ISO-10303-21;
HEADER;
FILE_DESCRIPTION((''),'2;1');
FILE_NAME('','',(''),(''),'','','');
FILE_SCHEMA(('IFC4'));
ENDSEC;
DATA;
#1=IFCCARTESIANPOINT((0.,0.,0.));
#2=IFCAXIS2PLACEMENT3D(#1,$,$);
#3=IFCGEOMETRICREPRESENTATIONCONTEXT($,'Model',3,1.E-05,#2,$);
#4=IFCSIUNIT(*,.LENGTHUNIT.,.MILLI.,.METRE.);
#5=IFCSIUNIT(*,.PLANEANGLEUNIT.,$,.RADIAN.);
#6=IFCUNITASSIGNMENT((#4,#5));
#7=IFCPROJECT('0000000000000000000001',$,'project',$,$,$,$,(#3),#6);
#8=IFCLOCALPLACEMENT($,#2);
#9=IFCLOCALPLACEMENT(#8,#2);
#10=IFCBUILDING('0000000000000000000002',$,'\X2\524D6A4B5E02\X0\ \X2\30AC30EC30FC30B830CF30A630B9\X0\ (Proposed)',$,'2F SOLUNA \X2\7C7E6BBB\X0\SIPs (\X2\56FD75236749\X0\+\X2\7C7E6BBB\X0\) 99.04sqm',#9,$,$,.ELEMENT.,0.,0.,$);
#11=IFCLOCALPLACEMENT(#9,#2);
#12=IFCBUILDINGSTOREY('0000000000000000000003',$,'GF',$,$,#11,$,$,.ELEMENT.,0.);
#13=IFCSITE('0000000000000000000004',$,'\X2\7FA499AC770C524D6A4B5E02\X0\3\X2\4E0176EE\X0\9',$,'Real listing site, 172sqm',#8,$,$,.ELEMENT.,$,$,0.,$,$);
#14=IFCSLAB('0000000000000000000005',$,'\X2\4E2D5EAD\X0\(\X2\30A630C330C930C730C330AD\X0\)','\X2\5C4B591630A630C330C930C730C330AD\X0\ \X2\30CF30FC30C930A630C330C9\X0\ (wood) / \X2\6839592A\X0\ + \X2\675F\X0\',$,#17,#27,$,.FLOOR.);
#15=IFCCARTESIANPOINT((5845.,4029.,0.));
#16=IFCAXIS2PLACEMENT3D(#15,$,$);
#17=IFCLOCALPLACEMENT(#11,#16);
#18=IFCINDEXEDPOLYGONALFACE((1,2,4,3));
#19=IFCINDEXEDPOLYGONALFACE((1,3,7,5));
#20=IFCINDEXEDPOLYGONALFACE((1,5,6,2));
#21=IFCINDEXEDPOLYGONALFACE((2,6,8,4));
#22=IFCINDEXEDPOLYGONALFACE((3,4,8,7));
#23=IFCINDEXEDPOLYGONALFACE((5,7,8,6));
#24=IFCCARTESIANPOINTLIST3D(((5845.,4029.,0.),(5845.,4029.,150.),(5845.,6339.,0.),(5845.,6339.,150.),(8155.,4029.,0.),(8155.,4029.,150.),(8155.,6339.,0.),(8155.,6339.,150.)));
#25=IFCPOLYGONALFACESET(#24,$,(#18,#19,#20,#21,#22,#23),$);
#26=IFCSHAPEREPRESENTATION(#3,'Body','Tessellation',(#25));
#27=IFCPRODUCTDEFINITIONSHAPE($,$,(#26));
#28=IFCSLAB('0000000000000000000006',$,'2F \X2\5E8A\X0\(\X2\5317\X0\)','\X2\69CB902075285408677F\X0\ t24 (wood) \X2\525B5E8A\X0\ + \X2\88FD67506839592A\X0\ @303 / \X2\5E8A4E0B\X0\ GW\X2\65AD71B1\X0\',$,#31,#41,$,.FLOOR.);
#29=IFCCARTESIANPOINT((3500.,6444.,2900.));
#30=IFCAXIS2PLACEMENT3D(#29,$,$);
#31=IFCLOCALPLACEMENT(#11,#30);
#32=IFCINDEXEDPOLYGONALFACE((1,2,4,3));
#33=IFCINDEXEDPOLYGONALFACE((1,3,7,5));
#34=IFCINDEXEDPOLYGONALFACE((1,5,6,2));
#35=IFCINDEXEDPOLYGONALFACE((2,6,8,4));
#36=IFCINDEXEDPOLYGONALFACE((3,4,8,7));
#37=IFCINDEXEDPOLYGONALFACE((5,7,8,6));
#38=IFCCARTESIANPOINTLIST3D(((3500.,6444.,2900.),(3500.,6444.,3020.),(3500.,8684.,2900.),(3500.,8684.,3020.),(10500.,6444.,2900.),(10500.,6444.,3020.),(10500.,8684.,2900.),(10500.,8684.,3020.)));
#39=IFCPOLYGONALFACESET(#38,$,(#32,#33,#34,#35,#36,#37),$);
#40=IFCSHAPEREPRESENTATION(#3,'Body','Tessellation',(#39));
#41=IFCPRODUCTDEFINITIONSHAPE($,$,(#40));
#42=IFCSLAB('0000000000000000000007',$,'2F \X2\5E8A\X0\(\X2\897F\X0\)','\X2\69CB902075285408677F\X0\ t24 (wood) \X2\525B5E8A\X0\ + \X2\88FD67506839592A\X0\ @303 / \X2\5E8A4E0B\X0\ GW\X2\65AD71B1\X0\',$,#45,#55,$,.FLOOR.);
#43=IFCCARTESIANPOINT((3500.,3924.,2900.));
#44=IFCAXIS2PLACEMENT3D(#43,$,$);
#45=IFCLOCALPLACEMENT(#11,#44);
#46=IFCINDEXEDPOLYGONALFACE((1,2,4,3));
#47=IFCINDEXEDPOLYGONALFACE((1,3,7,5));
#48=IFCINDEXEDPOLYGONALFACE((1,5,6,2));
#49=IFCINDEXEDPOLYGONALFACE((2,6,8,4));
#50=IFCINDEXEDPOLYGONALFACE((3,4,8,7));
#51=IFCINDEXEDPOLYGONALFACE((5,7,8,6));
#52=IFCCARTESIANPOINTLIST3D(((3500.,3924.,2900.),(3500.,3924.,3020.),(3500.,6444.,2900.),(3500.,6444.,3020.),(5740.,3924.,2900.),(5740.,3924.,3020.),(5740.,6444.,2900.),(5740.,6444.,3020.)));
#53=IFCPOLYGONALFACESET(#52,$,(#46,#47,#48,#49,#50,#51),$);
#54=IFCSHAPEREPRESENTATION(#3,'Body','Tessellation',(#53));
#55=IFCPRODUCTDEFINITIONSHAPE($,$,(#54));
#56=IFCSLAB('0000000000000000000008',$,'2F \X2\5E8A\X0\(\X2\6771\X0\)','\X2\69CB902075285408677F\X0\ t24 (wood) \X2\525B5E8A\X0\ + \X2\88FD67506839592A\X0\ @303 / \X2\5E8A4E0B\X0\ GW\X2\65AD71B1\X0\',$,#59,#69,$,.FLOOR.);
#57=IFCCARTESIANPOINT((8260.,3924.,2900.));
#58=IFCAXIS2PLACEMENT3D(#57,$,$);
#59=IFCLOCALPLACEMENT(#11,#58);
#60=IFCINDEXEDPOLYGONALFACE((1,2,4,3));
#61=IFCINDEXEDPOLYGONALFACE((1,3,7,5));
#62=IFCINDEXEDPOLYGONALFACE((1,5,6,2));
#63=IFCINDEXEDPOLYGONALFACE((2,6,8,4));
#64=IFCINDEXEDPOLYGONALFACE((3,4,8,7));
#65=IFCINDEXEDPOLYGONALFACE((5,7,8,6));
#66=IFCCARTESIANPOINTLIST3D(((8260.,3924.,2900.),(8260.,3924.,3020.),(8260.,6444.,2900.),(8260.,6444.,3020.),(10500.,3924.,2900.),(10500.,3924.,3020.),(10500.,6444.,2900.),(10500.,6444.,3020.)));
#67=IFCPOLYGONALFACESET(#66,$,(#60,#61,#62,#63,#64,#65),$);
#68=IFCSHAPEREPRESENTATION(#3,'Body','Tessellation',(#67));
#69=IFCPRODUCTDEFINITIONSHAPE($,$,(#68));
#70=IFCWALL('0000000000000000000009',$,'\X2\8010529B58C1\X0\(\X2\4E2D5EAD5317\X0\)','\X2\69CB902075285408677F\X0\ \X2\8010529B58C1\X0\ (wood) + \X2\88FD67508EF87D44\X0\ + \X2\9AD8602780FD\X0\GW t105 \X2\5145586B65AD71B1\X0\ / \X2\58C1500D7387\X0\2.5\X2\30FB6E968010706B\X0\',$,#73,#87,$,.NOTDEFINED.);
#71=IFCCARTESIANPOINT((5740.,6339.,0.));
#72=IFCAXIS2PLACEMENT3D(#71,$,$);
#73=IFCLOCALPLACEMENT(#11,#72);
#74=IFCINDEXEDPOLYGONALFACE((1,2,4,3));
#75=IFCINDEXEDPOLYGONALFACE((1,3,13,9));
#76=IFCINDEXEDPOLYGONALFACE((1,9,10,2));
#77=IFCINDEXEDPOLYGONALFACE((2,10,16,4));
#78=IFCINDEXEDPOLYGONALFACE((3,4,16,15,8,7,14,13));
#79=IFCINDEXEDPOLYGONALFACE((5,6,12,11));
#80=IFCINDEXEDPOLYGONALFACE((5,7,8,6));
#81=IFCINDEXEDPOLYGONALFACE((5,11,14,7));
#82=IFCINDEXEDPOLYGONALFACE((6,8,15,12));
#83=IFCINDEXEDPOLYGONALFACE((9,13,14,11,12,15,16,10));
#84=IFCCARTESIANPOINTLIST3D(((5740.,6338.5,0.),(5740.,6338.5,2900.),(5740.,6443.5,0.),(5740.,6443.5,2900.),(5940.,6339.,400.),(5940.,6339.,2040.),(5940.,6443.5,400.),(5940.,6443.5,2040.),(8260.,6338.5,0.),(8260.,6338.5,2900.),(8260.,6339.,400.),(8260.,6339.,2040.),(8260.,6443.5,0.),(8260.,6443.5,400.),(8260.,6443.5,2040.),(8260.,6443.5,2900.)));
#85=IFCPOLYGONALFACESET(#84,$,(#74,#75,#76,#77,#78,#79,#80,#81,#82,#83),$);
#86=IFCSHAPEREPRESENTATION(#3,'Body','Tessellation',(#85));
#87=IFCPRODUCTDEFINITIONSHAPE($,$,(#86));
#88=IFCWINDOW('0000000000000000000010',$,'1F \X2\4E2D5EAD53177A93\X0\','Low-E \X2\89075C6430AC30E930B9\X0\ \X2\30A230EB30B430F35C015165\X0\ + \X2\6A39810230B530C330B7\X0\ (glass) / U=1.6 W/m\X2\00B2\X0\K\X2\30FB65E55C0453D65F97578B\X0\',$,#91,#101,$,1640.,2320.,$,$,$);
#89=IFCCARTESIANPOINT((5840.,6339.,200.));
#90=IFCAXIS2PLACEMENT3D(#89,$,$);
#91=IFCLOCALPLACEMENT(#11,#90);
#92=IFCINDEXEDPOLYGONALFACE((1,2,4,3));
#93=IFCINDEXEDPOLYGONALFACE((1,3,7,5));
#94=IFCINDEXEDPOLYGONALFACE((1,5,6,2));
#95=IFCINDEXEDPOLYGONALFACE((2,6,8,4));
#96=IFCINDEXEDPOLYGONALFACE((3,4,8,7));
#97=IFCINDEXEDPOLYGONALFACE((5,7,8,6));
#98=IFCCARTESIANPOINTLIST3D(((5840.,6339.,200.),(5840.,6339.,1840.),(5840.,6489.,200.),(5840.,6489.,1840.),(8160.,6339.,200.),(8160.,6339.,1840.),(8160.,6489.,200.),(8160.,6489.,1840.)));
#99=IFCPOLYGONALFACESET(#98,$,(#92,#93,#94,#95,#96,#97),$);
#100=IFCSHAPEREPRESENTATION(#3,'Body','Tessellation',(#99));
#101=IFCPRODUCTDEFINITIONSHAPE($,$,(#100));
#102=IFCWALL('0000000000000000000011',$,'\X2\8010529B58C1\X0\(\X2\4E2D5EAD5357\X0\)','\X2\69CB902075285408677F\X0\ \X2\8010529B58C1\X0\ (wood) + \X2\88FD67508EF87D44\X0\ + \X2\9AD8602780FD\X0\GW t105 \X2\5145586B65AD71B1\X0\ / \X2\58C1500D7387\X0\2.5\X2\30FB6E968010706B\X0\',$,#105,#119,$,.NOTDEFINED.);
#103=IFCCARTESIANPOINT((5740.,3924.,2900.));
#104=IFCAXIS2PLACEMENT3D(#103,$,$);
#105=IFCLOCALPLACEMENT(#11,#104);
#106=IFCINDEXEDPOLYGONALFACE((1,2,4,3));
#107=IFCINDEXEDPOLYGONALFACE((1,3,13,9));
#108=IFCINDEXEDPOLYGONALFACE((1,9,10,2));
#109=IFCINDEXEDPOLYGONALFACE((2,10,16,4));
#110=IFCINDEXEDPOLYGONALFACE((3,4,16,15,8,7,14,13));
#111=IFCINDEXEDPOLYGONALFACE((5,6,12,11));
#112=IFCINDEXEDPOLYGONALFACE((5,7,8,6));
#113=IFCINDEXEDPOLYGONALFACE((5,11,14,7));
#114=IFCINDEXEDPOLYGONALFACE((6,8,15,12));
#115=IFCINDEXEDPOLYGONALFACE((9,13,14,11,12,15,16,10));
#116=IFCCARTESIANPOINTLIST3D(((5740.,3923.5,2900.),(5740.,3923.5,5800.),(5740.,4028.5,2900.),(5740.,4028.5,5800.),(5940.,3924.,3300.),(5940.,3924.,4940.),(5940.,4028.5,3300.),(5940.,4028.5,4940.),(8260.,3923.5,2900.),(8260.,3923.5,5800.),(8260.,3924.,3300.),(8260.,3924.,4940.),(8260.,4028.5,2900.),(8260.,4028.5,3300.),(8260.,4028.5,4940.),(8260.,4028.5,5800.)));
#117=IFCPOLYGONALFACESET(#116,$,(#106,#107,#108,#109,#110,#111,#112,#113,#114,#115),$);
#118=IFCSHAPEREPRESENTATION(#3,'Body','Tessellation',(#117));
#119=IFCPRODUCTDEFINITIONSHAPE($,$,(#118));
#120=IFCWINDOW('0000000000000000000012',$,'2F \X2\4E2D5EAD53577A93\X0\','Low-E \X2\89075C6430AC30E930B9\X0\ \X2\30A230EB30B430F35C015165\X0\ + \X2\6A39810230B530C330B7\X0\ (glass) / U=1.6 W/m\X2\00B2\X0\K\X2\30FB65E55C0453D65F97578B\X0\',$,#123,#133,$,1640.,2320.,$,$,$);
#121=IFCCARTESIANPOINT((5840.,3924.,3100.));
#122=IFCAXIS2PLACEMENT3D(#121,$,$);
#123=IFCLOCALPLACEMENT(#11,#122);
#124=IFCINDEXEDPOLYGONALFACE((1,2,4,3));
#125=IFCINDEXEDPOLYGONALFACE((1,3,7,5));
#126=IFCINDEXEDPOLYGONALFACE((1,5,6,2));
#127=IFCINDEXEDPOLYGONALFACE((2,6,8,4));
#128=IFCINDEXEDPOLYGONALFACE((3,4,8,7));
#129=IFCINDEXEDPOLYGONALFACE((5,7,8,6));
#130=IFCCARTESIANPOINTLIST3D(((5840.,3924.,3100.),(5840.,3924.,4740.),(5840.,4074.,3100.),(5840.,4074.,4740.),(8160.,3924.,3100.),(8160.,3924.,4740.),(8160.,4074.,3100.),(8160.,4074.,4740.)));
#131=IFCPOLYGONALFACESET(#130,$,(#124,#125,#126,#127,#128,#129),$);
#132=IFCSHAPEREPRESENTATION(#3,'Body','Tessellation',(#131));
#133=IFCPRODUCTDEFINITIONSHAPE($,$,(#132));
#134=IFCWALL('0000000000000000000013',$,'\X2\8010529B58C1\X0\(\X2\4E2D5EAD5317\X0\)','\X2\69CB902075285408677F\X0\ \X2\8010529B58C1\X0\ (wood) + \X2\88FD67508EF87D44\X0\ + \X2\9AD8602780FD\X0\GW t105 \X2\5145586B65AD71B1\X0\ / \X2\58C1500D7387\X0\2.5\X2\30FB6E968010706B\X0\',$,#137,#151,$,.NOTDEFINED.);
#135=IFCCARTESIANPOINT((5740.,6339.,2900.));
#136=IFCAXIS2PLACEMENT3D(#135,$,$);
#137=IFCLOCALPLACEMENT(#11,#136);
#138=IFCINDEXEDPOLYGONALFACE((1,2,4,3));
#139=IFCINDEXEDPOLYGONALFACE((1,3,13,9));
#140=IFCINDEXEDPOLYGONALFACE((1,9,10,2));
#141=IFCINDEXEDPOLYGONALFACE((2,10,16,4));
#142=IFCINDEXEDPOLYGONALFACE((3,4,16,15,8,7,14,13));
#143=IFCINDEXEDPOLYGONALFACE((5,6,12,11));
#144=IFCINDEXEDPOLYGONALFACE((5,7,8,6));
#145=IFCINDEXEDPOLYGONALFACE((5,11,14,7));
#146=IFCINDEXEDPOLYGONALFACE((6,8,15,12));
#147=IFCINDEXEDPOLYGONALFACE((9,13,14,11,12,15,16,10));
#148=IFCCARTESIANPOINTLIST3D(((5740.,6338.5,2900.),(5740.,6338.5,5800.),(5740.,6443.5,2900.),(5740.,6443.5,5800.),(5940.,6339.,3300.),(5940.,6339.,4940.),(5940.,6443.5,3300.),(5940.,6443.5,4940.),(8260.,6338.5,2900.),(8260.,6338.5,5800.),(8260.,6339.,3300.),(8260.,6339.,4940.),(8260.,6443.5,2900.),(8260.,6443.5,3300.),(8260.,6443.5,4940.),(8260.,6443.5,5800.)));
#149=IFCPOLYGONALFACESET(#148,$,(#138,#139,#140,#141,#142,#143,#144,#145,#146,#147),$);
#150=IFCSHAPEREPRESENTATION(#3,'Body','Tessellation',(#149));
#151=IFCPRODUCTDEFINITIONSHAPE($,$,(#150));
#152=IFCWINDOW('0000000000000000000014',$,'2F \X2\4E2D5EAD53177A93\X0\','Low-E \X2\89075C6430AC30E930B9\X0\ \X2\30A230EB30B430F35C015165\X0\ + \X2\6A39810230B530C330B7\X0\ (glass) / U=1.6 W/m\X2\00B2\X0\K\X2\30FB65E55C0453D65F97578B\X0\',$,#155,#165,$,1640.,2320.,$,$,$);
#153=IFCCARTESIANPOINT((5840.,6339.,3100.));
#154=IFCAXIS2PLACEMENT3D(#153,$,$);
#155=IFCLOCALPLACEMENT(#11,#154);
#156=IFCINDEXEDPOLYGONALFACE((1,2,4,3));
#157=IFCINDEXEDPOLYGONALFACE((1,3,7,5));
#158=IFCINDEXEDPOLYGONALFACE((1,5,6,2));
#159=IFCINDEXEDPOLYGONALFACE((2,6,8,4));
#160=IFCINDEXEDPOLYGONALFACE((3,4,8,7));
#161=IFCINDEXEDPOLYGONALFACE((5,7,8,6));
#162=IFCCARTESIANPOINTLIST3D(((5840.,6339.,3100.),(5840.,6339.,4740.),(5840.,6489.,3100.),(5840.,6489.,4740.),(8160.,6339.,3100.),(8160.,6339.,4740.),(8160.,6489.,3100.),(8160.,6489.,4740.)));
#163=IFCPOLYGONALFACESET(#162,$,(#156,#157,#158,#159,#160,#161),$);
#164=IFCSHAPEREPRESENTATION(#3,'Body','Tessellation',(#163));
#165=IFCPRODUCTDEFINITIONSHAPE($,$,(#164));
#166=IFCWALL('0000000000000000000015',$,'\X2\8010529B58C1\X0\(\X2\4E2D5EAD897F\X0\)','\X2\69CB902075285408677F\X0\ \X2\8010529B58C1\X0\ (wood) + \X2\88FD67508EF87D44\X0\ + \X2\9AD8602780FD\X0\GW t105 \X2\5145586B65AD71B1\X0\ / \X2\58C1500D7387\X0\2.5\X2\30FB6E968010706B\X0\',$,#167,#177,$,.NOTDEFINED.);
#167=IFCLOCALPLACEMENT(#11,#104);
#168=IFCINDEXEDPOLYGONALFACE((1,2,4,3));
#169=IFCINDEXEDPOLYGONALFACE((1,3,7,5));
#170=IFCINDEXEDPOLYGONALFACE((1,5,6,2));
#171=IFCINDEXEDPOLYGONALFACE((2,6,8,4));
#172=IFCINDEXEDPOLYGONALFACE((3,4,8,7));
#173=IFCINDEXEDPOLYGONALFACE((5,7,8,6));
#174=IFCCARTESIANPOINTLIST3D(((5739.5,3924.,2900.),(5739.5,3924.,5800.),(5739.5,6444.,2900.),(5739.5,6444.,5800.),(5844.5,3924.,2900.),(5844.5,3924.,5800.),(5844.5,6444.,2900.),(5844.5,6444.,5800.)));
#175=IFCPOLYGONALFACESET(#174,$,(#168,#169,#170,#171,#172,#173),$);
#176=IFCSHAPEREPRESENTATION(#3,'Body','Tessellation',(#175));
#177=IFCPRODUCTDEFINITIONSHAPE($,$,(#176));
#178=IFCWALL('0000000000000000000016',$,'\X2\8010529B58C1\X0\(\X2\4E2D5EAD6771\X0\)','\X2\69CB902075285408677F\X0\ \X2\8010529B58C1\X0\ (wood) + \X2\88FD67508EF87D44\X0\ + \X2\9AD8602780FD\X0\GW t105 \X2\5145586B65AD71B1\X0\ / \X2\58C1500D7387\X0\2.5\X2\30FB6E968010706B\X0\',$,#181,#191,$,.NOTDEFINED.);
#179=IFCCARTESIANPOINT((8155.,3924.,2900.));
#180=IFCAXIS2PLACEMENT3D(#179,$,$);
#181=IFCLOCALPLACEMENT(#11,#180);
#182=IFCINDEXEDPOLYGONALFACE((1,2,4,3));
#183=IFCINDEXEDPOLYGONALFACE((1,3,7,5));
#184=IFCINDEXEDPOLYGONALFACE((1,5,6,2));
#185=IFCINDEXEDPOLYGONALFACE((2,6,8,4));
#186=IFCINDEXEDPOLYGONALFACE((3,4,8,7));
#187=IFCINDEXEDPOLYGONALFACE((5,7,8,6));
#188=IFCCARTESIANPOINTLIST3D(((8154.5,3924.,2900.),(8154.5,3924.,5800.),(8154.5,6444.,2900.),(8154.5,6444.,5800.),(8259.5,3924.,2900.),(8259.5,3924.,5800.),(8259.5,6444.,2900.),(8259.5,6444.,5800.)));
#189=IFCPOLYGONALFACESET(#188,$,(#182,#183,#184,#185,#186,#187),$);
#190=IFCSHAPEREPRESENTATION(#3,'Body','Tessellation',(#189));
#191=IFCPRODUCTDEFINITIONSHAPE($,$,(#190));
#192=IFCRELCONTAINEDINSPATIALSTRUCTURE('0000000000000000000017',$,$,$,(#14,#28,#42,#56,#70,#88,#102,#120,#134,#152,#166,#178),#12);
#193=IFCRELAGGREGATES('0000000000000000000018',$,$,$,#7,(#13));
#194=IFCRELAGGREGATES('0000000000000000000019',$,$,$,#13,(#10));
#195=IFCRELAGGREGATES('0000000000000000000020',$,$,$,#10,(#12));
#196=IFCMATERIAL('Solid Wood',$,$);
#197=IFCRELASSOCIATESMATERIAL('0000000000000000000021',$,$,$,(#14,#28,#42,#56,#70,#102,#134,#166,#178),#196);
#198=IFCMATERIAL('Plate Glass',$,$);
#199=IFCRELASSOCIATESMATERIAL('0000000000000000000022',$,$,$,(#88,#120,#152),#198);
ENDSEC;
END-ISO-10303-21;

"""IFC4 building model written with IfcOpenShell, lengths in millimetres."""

from ifc_helpers import new_model, si_unit, frame, frame_2d, origin, place, context, project, spatial, rectangle, extrude, material, element, fill, save


model = new_model("IFC4")

# Units and contexts
model_context = context("Model", 3, precision=1e-05, world=origin())
ifc_project = project(units=[si_unit("LENGTHUNIT", "METRE", prefix="MILLI"), si_unit("PLANEANGLEUNIT", "RADIAN")], contexts=[model_context])

# Site, building, storey
site_placement = place(None, origin())
site = spatial("IfcSite", under=ifc_project, at=site_placement, Name="群馬県前橋市3丁目9", ObjectType="Real listing site, 172sqm", CompositionType="ELEMENT", RefElevation=0.0)
building_placement = place(site_placement, origin())
building = spatial("IfcBuilding", under=site, at=building_placement, Name="前橋市 ガレージハウス (Proposed)", ObjectType="2F SOLUNA 籾殻SIPs (国産杉+籾殻) 99.04sqm", CompositionType="ELEMENT", ElevationOfRefHeight=0.0, ElevationOfTerrain=0.0)
storey_placement = place(building_placement, origin())
storey = spatial("IfcBuildingStorey", under=building, at=storey_placement, Name="GF", CompositionType="ELEMENT", Elevation=0.0)

# Slabs
ifc_material_1 = material(Name="Solid Wood")
slab_1_placement = place(storey_placement, frame((5845.0, 4029.0, 0.0)))
element("IfcSlab", 1, at=slab_1_placement, inside=storey, material=ifc_material_1, Name="中庭(ウッドデッキ)", Description="屋外ウッドデッキ ハードウッド (wood) / 根太 + 束", PredefinedType="FLOOR", context=model_context, shape_type="SweptSolid", body=[
    extrude(rectangle(XDim=2310.0, YDim=2310.0, at=frame_2d((1155.0, 1155.0))), frame((5845.0, 4029.0, 0.0)), (0.0, 0.0, 1.0), 150.0),
])
slab_2_placement = place(storey_placement, frame((3500.0, 6444.0, 2900.0)))
element("IfcSlab", 2, at=slab_2_placement, inside=storey, material=ifc_material_1, Name="2F 床(北)", Description="構造用合板 t24 (wood) 剛床 + 製材根太 @303 / 床下 GW断熱", PredefinedType="FLOOR", context=model_context, shape_type="SweptSolid", body=[
    extrude(rectangle(XDim=7000.0, YDim=2240.0, at=frame_2d((3500.0, 1120.0))), frame((3500.0, 6444.0, 2900.0)), (0.0, 0.0, 1.0), 120.0),
])
slab_3_placement = place(storey_placement, frame((3500.0, 3924.0, 2900.0)))
element("IfcSlab", 3, at=slab_3_placement, inside=storey, material=ifc_material_1, Name="2F 床(西)", Description="構造用合板 t24 (wood) 剛床 + 製材根太 @303 / 床下 GW断熱", PredefinedType="FLOOR", context=model_context, shape_type="SweptSolid", body=[
    extrude(rectangle(XDim=2240.0, YDim=2520.0, at=frame_2d((1120.0, 1260.0))), frame((3500.0, 3924.0, 2900.0)), (0.0, 0.0, 1.0), 120.0),
])
slab_4_placement = place(storey_placement, frame((8260.0, 3924.0, 2900.0)))
element("IfcSlab", 4, at=slab_4_placement, inside=storey, material=ifc_material_1, Name="2F 床(東)", Description="構造用合板 t24 (wood) 剛床 + 製材根太 @303 / 床下 GW断熱", PredefinedType="FLOOR", context=model_context, shape_type="SweptSolid", body=[
    extrude(rectangle(XDim=2240.0, YDim=2520.0, at=frame_2d((1120.0, 1260.0))), frame((8260.0, 3924.0, 2900.0)), (0.0, 0.0, 1.0), 120.0),
])

# Wall, opening, window
wall_1_placement = place(storey_placement, frame((5740.0, 6339.0, 0.0)))
wall_1 = element("IfcWall", 5, at=wall_1_placement, inside=storey, material=ifc_material_1, Name="耐力壁(中庭北)", Description="構造用合板 耐力壁 (wood) + 製材軸組 + 高性能GW t105 充填断熱 / 壁倍率2.5・準耐火", PredefinedType="NOTDEFINED", context=model_context, shape_type="SweptSolid", body=[
    extrude(rectangle(XDim=2520.0, YDim=105.0, at=frame_2d((1260.0, 52.0))), frame((5740.0, 6339.0, 0.0)), (0.0, 0.0, 1.0), 2900.0),
])
opening_1_placement = place(storey_placement, frame((5840.0, 6339.0, 200.0)))
opening_1 = element("IfcOpeningElement", 6, at=opening_1_placement, cuts=wall_1, PredefinedType="NOTDEFINED", context=model_context, shape_type="SweptSolid", body=[
    extrude(rectangle(XDim=2320.0, YDim=150.0, at=frame_2d((1160.0, 75.0))), frame((5840.0, 6339.0, 200.0)), (0.0, 0.0, 1.0), 1640.0),
])
ifc_material_2 = material(Name="Plate Glass")
window_1_placement = place(storey_placement, frame((5840.0, 6339.0, 200.0)))
window_1 = element("IfcWindow", 7, at=window_1_placement, inside=storey, material=ifc_material_2, Name="1F 中庭北窓", Description="Low-E 複層ガラス アルゴン封入 + 樹脂サッシ (glass) / U=1.6 W/m²K・日射取得型", OverallHeight=1640.0, OverallWidth=2320.0, context=model_context, shape_type="SweptSolid", body=[
    extrude(rectangle(XDim=2320.0, YDim=150.0, at=frame_2d((1160.0, 75.0))), frame((5840.0, 6339.0, 200.0)), (0.0, 0.0, 1.0), 1640.0),
])
fill(opening_1, window_1)

# Walls, openings, windows
wall_2_placement = place(storey_placement, frame((5740.0, 3924.0, 2900.0)))
wall_2 = element("IfcWall", 8, at=wall_2_placement, inside=storey, material=ifc_material_1, Name="耐力壁(中庭南)", Description="構造用合板 耐力壁 (wood) + 製材軸組 + 高性能GW t105 充填断熱 / 壁倍率2.5・準耐火", PredefinedType="NOTDEFINED", context=model_context, shape_type="SweptSolid", body=[
    extrude(rectangle(XDim=2520.0, YDim=105.0, at=frame_2d((1260.0, 52.0))), frame((5740.0, 3924.0, 2900.0)), (0.0, 0.0, 1.0), 2900.0),
])
opening_2_placement = place(storey_placement, frame((5840.0, 3924.0, 3100.0)))
opening_2 = element("IfcOpeningElement", 9, at=opening_2_placement, cuts=wall_2, PredefinedType="NOTDEFINED", context=model_context, shape_type="SweptSolid", body=[
    extrude(rectangle(XDim=2320.0, YDim=150.0, at=frame_2d((1160.0, 75.0))), frame((5840.0, 3924.0, 3100.0)), (0.0, 0.0, 1.0), 1640.0),
])
window_2_placement = place(storey_placement, frame((5840.0, 3924.0, 3100.0)))
window_2 = element("IfcWindow", 10, at=window_2_placement, inside=storey, material=ifc_material_2, Name="2F 中庭南窓", Description="Low-E 複層ガラス アルゴン封入 + 樹脂サッシ (glass) / U=1.6 W/m²K・日射取得型", OverallHeight=1640.0, OverallWidth=2320.0, context=model_context, shape_type="SweptSolid", body=[
    extrude(rectangle(XDim=2320.0, YDim=150.0, at=frame_2d((1160.0, 75.0))), frame((5840.0, 3924.0, 3100.0)), (0.0, 0.0, 1.0), 1640.0),
])
fill(opening_2, window_2)
wall_3_placement = place(storey_placement, frame((5740.0, 6339.0, 2900.0)))
wall_3 = element("IfcWall", 11, at=wall_3_placement, inside=storey, material=ifc_material_1, Name="耐力壁(中庭北)", Description="構造用合板 耐力壁 (wood) + 製材軸組 + 高性能GW t105 充填断熱 / 壁倍率2.5・準耐火", PredefinedType="NOTDEFINED", context=model_context, shape_type="SweptSolid", body=[
    extrude(rectangle(XDim=2520.0, YDim=105.0, at=frame_2d((1260.0, 52.0))), frame((5740.0, 6339.0, 2900.0)), (0.0, 0.0, 1.0), 2900.0),
])
opening_3_placement = place(storey_placement, frame((5840.0, 6339.0, 3100.0)))
opening_3 = element("IfcOpeningElement", 12, at=opening_3_placement, cuts=wall_3, PredefinedType="NOTDEFINED", context=model_context, shape_type="SweptSolid", body=[
    extrude(rectangle(XDim=2320.0, YDim=150.0, at=frame_2d((1160.0, 75.0))), frame((5840.0, 6339.0, 3100.0)), (0.0, 0.0, 1.0), 1640.0),
])
window_3_placement = place(storey_placement, frame((5840.0, 6339.0, 3100.0)))
window_3 = element("IfcWindow", 13, at=window_3_placement, inside=storey, material=ifc_material_2, Name="2F 中庭北窓", Description="Low-E 複層ガラス アルゴン封入 + 樹脂サッシ (glass) / U=1.6 W/m²K・日射取得型", OverallHeight=1640.0, OverallWidth=2320.0, context=model_context, shape_type="SweptSolid", body=[
    extrude(rectangle(XDim=2320.0, YDim=150.0, at=frame_2d((1160.0, 75.0))), frame((5840.0, 6339.0, 3100.0)), (0.0, 0.0, 1.0), 1640.0),
])
fill(opening_3, window_3)

# Walls
wall_4_placement = place(storey_placement, frame((5740.0, 3924.0, 2900.0)))
element("IfcWall", 14, at=wall_4_placement, inside=storey, material=ifc_material_1, Name="耐力壁(中庭西)", Description="構造用合板 耐力壁 (wood) + 製材軸組 + 高性能GW t105 充填断熱 / 壁倍率2.5・準耐火", PredefinedType="NOTDEFINED", context=model_context, shape_type="SweptSolid", body=[
    extrude(rectangle(XDim=105.0, YDim=2520.0, at=frame_2d((52.0, 1260.0))), frame((5740.0, 3924.0, 2900.0)), (0.0, 0.0, 1.0), 2900.0),
])
wall_5_placement = place(storey_placement, frame((8155.0, 3924.0, 2900.0)))
element("IfcWall", 15, at=wall_5_placement, inside=storey, material=ifc_material_1, Name="耐力壁(中庭東)", Description="構造用合板 耐力壁 (wood) + 製材軸組 + 高性能GW t105 充填断熱 / 壁倍率2.5・準耐火", PredefinedType="NOTDEFINED", context=model_context, shape_type="SweptSolid", body=[
    extrude(rectangle(XDim=105.0, YDim=2520.0, at=frame_2d((52.0, 1260.0))), frame((8155.0, 3924.0, 2900.0)), (0.0, 0.0, 1.0), 2900.0),
])

save(model, "model.ifc")
